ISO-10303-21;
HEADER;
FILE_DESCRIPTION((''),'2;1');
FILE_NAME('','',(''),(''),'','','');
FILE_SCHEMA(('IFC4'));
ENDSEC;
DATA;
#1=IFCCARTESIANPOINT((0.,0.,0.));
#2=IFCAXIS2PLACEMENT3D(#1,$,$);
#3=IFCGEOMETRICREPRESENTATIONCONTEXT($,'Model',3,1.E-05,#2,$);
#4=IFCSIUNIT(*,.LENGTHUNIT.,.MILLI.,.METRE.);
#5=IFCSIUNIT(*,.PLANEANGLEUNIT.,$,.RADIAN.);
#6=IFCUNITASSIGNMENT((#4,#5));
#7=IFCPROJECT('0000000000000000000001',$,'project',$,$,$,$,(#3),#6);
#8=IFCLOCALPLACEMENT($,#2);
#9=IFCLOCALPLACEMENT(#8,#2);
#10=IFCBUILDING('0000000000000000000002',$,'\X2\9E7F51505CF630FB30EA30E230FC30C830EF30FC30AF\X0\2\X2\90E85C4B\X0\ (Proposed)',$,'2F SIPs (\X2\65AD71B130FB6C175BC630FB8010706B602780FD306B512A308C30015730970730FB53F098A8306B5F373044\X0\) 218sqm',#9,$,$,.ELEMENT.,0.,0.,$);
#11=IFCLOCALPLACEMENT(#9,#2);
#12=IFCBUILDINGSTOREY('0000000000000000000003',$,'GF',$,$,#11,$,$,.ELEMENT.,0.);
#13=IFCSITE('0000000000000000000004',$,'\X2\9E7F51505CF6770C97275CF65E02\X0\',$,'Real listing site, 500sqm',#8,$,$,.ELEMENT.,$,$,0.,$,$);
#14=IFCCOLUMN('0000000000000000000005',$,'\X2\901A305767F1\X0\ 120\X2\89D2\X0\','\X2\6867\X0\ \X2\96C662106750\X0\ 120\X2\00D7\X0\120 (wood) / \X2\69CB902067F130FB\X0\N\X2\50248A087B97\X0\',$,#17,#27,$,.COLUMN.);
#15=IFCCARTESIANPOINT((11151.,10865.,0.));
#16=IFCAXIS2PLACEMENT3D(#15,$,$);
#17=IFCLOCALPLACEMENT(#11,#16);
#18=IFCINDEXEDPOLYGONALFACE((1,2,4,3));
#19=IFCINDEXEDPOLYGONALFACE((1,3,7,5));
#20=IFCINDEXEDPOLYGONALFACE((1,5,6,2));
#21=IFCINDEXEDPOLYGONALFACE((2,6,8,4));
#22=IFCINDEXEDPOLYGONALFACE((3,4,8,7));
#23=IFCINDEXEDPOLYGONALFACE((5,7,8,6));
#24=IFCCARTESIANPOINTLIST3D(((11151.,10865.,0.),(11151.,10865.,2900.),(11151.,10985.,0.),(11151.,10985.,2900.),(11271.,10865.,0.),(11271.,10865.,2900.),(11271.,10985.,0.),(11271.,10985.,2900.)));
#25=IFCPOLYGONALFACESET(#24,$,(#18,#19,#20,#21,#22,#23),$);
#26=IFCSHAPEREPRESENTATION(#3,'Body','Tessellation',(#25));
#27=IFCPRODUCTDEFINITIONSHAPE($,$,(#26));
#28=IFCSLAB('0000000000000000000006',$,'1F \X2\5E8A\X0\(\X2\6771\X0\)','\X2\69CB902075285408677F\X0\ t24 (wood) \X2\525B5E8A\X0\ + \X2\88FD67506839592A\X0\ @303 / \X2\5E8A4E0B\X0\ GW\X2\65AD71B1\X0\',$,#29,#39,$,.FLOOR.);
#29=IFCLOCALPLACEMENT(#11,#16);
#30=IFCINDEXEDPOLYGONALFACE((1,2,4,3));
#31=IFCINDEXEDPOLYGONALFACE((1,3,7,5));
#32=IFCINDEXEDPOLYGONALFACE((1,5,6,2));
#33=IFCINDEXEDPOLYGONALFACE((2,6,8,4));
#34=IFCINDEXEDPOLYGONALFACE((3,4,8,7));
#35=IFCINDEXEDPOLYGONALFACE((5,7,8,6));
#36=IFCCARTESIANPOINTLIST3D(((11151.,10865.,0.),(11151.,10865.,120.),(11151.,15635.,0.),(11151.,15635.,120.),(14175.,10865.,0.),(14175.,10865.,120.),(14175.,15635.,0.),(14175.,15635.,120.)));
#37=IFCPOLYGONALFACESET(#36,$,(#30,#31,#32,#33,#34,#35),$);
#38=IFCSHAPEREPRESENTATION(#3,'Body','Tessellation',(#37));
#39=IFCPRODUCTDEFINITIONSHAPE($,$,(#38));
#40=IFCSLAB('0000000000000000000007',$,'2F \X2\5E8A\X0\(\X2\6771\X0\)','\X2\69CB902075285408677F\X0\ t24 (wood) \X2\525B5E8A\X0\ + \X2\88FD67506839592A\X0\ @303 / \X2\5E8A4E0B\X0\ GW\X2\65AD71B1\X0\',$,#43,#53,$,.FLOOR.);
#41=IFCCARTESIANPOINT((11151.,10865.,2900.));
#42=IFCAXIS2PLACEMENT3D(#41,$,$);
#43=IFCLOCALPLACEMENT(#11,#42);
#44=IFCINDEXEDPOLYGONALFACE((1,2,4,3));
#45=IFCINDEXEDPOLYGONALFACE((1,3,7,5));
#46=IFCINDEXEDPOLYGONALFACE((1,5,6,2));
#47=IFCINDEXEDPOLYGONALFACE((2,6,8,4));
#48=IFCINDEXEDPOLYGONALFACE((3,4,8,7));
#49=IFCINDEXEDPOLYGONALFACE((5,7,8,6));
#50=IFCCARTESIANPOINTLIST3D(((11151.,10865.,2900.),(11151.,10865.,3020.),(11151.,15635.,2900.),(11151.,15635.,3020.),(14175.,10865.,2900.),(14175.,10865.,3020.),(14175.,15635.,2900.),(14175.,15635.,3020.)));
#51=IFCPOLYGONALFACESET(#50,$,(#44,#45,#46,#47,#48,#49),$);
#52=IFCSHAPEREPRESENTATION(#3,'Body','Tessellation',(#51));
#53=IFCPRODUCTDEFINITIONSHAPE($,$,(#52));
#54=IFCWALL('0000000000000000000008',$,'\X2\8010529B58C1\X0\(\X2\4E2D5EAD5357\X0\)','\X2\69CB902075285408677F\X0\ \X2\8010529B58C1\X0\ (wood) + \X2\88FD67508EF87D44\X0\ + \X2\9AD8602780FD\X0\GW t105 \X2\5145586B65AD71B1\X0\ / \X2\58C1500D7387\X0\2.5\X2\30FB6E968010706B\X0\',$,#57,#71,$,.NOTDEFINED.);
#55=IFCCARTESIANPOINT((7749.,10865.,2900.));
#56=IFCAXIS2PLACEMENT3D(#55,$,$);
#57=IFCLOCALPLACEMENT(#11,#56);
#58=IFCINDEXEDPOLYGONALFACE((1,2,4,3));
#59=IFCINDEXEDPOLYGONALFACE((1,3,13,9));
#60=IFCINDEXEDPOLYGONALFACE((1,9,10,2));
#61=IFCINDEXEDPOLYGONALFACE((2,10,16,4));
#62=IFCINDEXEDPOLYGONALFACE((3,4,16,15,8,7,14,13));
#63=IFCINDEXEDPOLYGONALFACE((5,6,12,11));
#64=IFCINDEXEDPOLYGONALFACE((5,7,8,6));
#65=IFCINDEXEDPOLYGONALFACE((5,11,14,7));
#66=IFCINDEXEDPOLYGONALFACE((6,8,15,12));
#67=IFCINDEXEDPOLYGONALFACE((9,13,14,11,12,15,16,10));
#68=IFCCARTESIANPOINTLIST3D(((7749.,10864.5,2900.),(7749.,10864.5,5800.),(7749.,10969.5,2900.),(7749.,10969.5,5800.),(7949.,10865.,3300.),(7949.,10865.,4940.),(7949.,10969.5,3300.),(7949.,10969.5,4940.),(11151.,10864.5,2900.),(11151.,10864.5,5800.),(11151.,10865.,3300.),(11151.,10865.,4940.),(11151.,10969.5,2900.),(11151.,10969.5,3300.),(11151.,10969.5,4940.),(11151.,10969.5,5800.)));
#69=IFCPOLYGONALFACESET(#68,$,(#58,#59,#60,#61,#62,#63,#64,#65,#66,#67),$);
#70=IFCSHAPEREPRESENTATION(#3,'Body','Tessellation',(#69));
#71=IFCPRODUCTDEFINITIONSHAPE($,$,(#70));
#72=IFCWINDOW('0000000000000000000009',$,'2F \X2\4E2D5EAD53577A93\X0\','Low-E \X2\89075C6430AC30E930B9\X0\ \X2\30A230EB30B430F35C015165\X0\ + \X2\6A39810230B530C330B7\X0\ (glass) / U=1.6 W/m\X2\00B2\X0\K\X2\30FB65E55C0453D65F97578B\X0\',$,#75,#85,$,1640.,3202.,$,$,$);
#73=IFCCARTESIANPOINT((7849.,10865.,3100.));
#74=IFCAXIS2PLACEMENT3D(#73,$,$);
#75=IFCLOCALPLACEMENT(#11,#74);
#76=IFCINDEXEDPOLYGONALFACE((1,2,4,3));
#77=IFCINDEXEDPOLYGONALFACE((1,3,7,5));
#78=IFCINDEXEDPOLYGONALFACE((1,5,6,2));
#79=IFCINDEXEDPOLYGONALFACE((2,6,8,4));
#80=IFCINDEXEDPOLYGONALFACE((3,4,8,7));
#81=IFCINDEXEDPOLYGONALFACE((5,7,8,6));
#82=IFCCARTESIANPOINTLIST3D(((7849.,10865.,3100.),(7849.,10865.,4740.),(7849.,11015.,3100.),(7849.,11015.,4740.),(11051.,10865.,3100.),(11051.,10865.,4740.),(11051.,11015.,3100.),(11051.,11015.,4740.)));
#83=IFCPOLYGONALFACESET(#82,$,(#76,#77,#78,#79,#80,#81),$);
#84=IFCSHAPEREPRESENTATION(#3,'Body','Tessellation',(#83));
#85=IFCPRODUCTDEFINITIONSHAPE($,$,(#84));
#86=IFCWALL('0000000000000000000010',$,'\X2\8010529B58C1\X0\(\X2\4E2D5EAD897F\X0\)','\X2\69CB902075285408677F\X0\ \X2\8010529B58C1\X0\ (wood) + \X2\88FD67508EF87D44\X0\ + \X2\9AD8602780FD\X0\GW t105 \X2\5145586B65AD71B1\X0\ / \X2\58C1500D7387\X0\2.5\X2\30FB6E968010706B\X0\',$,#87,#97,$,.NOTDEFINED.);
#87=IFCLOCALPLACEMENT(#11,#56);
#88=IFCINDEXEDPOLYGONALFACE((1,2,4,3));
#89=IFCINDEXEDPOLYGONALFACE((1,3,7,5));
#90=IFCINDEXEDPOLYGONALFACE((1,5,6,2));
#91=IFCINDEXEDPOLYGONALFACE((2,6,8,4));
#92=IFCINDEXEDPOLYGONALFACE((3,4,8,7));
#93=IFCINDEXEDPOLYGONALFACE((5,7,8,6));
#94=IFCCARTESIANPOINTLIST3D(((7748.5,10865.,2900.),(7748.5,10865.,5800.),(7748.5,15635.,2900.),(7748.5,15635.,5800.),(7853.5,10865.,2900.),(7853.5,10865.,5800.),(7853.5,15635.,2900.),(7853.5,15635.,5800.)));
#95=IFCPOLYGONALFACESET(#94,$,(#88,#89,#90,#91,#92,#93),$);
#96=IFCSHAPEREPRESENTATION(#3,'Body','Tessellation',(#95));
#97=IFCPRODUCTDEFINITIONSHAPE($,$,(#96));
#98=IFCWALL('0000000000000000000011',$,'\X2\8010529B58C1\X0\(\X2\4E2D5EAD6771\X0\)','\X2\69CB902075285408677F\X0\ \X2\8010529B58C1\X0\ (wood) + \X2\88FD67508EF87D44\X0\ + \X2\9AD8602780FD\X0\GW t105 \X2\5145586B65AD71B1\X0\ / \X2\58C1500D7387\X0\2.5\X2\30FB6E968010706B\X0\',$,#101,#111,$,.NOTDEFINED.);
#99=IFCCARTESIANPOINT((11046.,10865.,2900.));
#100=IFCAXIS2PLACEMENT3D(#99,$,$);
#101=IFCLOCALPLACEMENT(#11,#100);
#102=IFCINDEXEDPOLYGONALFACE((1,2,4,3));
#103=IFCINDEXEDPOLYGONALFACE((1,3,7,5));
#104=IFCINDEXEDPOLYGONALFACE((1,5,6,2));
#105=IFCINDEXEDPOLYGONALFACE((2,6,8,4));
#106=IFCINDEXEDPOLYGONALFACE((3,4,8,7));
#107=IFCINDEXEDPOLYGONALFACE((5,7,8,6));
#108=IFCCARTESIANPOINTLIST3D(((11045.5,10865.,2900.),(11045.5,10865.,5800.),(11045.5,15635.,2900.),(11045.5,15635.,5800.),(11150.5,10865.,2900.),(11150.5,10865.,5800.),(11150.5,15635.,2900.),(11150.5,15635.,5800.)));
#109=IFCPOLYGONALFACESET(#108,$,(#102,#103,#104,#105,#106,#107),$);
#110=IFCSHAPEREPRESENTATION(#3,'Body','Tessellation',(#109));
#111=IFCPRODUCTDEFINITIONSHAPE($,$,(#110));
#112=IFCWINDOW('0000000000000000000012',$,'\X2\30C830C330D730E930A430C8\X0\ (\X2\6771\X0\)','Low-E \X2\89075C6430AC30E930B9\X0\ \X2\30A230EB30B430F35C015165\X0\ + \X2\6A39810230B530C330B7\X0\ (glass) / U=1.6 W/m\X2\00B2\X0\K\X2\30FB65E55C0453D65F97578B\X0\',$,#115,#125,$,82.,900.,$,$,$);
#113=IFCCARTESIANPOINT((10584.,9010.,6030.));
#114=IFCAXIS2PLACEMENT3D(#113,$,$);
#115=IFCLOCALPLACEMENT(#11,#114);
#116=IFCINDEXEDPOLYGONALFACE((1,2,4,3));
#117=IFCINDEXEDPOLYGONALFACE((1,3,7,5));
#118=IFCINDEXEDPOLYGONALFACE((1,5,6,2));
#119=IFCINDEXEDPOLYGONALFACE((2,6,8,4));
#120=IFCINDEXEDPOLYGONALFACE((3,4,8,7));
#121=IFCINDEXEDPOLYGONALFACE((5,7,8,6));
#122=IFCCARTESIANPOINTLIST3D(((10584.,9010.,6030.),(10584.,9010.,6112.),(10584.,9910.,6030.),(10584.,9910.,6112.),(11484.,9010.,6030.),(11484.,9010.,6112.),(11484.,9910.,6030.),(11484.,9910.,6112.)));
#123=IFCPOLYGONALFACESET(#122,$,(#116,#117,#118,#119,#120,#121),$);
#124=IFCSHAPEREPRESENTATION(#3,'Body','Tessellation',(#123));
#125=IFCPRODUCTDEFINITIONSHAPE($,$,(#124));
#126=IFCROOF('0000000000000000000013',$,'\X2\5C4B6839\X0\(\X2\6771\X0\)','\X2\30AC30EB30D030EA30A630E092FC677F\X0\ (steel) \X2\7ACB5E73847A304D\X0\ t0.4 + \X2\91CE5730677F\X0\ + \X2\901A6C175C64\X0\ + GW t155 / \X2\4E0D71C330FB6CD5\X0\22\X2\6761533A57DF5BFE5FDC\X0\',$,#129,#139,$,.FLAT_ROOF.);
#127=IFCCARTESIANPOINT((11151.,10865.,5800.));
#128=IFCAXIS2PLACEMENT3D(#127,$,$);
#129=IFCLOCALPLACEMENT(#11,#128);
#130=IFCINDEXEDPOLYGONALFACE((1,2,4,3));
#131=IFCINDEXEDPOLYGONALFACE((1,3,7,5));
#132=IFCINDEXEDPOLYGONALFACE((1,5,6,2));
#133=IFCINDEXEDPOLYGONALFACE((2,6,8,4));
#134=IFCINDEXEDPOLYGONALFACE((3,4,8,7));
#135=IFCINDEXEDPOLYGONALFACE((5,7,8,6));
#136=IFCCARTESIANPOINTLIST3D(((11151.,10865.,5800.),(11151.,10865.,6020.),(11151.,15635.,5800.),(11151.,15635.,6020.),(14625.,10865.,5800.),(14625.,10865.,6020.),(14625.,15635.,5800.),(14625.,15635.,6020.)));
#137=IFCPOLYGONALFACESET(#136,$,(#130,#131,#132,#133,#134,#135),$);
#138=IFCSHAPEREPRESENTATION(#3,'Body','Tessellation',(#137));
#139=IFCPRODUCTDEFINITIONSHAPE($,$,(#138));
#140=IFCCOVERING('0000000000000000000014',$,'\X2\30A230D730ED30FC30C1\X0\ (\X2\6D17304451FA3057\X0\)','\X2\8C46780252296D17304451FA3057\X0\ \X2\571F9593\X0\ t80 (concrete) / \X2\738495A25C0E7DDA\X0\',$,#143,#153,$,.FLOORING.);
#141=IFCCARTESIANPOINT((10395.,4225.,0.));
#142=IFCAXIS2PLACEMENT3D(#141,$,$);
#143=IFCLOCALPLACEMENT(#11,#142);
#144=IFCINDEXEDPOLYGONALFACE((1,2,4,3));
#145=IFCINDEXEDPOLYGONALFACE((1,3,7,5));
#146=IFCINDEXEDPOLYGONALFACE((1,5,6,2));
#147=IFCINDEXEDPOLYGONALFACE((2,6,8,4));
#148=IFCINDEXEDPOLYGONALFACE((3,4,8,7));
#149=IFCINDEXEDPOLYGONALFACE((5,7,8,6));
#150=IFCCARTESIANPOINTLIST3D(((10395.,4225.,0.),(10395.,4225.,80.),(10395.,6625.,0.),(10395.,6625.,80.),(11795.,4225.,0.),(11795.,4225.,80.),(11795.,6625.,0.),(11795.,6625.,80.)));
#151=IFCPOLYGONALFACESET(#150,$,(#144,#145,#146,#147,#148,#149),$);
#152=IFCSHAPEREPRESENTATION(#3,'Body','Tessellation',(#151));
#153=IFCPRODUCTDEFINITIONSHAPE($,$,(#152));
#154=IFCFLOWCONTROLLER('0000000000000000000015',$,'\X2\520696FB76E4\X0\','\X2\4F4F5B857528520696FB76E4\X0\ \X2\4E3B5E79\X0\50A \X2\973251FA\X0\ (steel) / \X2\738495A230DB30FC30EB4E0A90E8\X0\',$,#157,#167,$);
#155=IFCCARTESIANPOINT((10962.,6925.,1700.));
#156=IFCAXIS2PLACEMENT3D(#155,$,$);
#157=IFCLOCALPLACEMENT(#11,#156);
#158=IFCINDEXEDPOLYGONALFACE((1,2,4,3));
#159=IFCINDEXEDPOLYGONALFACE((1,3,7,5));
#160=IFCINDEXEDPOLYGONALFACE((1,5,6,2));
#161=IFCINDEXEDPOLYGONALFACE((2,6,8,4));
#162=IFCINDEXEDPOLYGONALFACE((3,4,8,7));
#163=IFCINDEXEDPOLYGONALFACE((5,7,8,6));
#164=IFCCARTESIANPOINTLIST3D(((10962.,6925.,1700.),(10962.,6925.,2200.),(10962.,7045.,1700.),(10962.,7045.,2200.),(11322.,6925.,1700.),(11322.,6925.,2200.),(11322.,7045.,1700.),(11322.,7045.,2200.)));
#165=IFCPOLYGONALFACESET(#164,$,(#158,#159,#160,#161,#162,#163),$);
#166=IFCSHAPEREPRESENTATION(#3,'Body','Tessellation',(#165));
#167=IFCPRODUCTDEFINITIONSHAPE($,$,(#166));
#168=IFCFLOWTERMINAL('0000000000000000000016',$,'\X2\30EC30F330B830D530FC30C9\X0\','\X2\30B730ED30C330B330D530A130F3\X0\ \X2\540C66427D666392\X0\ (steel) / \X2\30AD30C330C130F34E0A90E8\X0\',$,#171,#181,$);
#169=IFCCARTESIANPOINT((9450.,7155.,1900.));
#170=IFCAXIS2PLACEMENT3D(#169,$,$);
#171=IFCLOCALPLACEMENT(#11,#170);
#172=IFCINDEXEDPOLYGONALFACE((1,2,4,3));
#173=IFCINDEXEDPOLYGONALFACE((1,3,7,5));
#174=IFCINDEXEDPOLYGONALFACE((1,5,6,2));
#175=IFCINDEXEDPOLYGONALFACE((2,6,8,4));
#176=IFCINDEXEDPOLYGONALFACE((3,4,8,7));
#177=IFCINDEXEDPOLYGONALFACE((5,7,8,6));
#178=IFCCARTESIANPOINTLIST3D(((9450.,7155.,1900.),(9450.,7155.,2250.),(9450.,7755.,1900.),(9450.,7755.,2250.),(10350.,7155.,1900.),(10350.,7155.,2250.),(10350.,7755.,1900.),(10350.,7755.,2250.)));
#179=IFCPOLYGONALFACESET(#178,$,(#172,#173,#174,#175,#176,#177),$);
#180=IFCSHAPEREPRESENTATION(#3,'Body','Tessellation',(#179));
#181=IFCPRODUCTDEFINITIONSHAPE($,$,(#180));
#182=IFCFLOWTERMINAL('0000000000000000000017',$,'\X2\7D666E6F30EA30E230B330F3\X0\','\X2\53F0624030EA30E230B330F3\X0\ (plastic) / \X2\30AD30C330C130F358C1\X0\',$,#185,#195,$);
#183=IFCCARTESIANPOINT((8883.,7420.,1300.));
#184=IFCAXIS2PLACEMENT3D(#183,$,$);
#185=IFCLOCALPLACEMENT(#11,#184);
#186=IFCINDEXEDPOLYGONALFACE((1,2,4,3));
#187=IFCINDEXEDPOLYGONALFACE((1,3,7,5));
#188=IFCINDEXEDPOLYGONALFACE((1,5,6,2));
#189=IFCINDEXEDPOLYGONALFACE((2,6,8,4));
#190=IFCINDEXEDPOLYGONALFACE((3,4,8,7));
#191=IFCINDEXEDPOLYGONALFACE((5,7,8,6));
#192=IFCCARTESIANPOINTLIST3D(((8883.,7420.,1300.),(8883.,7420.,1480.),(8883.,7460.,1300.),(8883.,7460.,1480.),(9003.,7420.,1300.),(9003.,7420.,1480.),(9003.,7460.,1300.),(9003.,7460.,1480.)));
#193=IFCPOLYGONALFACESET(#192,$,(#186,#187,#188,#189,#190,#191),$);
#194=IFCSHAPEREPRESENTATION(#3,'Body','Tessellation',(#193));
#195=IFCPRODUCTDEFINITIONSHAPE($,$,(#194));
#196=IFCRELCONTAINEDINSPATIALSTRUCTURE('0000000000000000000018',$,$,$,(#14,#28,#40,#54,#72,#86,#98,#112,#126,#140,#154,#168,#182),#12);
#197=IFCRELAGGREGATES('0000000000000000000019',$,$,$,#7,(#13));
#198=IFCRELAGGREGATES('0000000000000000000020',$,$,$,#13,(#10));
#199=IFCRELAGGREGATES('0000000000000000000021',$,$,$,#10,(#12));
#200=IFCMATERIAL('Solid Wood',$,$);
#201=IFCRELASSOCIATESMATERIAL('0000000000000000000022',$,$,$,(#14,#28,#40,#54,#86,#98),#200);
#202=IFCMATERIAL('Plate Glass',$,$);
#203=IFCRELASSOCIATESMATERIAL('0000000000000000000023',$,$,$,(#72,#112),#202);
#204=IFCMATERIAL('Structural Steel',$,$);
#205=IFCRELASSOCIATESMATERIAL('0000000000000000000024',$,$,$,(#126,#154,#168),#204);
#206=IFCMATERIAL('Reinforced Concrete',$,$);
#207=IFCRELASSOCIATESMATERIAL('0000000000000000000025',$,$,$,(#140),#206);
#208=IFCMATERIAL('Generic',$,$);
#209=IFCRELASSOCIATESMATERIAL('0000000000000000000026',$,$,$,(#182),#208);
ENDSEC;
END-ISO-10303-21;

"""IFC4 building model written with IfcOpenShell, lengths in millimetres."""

from ifc_helpers import new_model, si_unit, frame, frame_2d, origin, place, context, project, spatial, rectangle, extrude, material, element, fill, save


model = new_model("IFC4")

# Units and contexts
model_context = context("Model", 3, precision=1e-05, world=origin())
ifc_project = project(units=[si_unit("LENGTHUNIT", "METRE", prefix="MILLI"), si_unit("PLANEANGLEUNIT", "RADIAN")], contexts=[model_context])

# Site, building, storey
site_placement = place(None, origin())
site = spatial("IfcSite", under=ifc_project, at=site_placement, Name="鹿児島県霧島市", ObjectType="Real listing site, 500sqm", CompositionType="ELEMENT", RefElevation=0.0)
building_placement = place(site_placement, origin())
building = spatial("IfcBuilding", under=site, at=building_placement, Name="鹿児島・リモートワーク2部屋 (Proposed)", ObjectType="2F SIPs (断熱・気密・耐火性能に優れ、地震・台風に強い) 218sqm", CompositionType="ELEMENT", ElevationOfRefHeight=0.0, ElevationOfTerrain=0.0)
storey_placement = place(building_placement, origin())
storey = spatial("IfcBuildingStorey", under=building, at=storey_placement, Name="GF", CompositionType="ELEMENT", Elevation=0.0)

# Column
ifc_material_1 = material(Name="Solid Wood")
column_1_placement = place(storey_placement, frame((11151.0, 10865.0, 0.0)))
element("IfcColumn", 1, at=column_1_placement, inside=storey, material=ifc_material_1, Name="通し柱 120角", Description="桧 集成材 120×120 (wood) / 構造柱・N値計算", PredefinedType="COLUMN", context=model_context, shape_type="SweptSolid", body=[
    extrude(rectangle(XDim=120.0, YDim=120.0, at=frame_2d((60.0, 60.0))), frame((11151.0, 10865.0, 0.0)), (0.0, 0.0, 1.0), 2900.0),
])

# Slabs
slab_1_placement = place(storey_placement, frame((11151.0, 10865.0, 0.0)))
element("IfcSlab", 2, at=slab_1_placement, inside=storey, material=ifc_material_1, Name="1F 床(東)", Description="構造用合板 t24 (wood) 剛床 + 製材根太 @303 / 床下 GW断熱", PredefinedType="FLOOR", context=model_context, shape_type="SweptSolid", body=[
    extrude(rectangle(XDim=3024.0, YDim=4770.0, at=frame_2d((1512.0, 2385.0))), frame((11151.0, 10865.0, 0.0)), (0.0, 0.0, 1.0), 120.0),
])
slab_2_placement = place(storey_placement, frame((11151.0, 10865.0, 2900.0)))
element("IfcSlab", 3, at=slab_2_placement, inside=storey, material=ifc_material_1, Name="2F 床(東)", Description="構造用合板 t24 (wood) 剛床 + 製材根太 @303 / 床下 GW断熱", PredefinedType="FLOOR", context=model_context, shape_type="SweptSolid", body=[
    extrude(rectangle(XDim=3024.0, YDim=4770.0, at=frame_2d((1512.0, 2385.0))), frame((11151.0, 10865.0, 2900.0)), (0.0, 0.0, 1.0), 120.0),
])

# Wall, opening, window
wall_1_placement = place(storey_placement, frame((7749.0, 10865.0, 2900.0)))
wall_1 = element("IfcWall", 4, at=wall_1_placement, inside=storey, material=ifc_material_1, Name="耐力壁(中庭南)", Description="構造用合板 耐力壁 (wood) + 製材軸組 + 高性能GW t105 充填断熱 / 壁倍率2.5・準耐火", PredefinedType="NOTDEFINED", context=model_context, shape_type="SweptSolid", body=[
    extrude(rectangle(XDim=3402.0, YDim=105.0, at=frame_2d((1701.0, 52.0))), frame((7749.0, 10865.0, 2900.0)), (0.0, 0.0, 1.0), 2900.0),
])
opening_placement = place(storey_placement, frame((7849.0, 10865.0, 3100.0)))
opening = element("IfcOpeningElement", 5, at=opening_placement, cuts=wall_1, PredefinedType="NOTDEFINED", context=model_context, shape_type="SweptSolid", body=[
    extrude(rectangle(XDim=3202.0, YDim=150.0, at=frame_2d((1601.0, 75.0))), frame((7849.0, 10865.0, 3100.0)), (0.0, 0.0, 1.0), 1640.0),
])
ifc_material_2 = material(Name="Plate Glass")
window_1_placement = place(storey_placement, frame((7849.0, 10865.0, 3100.0)))
window_1 = element("IfcWindow", 6, at=window_1_placement, inside=storey, material=ifc_material_2, Name="2F 中庭南窓", Description="Low-E 複層ガラス アルゴン封入 + 樹脂サッシ (glass) / U=1.6 W/m²K・日射取得型", OverallHeight=1640.0, OverallWidth=3202.0, context=model_context, shape_type="SweptSolid", body=[
    extrude(rectangle(XDim=3202.0, YDim=150.0, at=frame_2d((1601.0, 75.0))), frame((7849.0, 10865.0, 3100.0)), (0.0, 0.0, 1.0), 1640.0),
])
fill(opening, window_1)

# Walls
wall_2_placement = place(storey_placement, frame((7749.0, 10865.0, 2900.0)))
element("IfcWall", 7, at=wall_2_placement, inside=storey, material=ifc_material_1, Name="耐力壁(中庭西)", Description="構造用合板 耐力壁 (wood) + 製材軸組 + 高性能GW t105 充填断熱 / 壁倍率2.5・準耐火", PredefinedType="NOTDEFINED", context=model_context, shape_type="SweptSolid", body=[
    extrude(rectangle(XDim=105.0, YDim=4770.0, at=frame_2d((52.0, 2385.0))), frame((7749.0, 10865.0, 2900.0)), (0.0, 0.0, 1.0), 2900.0),
])
wall_3_placement = place(storey_placement, frame((11046.0, 10865.0, 2900.0)))
element("IfcWall", 8, at=wall_3_placement, inside=storey, material=ifc_material_1, Name="耐力壁(中庭東)", Description="構造用合板 耐力壁 (wood) + 製材軸組 + 高性能GW t105 充填断熱 / 壁倍率2.5・準耐火", PredefinedType="NOTDEFINED", context=model_context, shape_type="SweptSolid", body=[
    extrude(rectangle(XDim=105.0, YDim=4770.0, at=frame_2d((52.0, 2385.0))), frame((11046.0, 10865.0, 2900.0)), (0.0, 0.0, 1.0), 2900.0),
])

# Window
window_2_placement = place(storey_placement, frame((10584.0, 9010.0, 6030.0)))
element("IfcWindow", 9, at=window_2_placement, inside=storey, material=ifc_material_2, Name="トップライト (東)", Description="Low-E 複層ガラス アルゴン封入 + 樹脂サッシ (glass) / U=1.6 W/m²K・日射取得型", OverallHeight=82.0, OverallWidth=900.0, context=model_context, shape_type="SweptSolid", body=[
    extrude(rectangle(XDim=900.0, YDim=900.0, at=frame_2d((450.0, 450.0))), frame((10584.0, 9010.0, 6030.0)), (0.0, 0.0, 1.0), 82.0),
])

# Roof
ifc_material_3 = material(Name="Structural Steel")
for number, where, name in (
    (10, (11151.0, 10865.0, 5800.0), "屋根(東)"),
):
    element("IfcRoof", number, at=place(storey_placement, frame(where)), inside=storey, material=ifc_material_3, Name=name, Description="ガルバリウム鋼板 (steel) 立平葺き t0.4 + 野地板 + 通気層 + GW t155 / 不燃・法22条区域対応", PredefinedType="FLAT_ROOF", context=model_context, shape_type="SweptSolid", body=[
        extrude(rectangle(XDim=3474.0, YDim=4770.0, at=frame_2d((1737.0, 2385.0))), frame((11151.0, 10865.0, 5800.0)), (0.0, 0.0, 1.0), 220.0),
    ])

# Covering
ifc_material_4 = material(Name="Reinforced Concrete")
covering_placement = place(storey_placement, frame((10395.0, 4225.0, 0.0)))
element("IfcCovering", 11, at=covering_placement, inside=storey, material=ifc_material_4, Name="アプローチ (洗い出し)", Description="豆砂利洗い出し 土間 t80 (concrete) / 玄関導線", PredefinedType="FLOORING", context=model_context, shape_type="SweptSolid", body=[
    extrude(rectangle(XDim=1400.0, YDim=2400.0, at=frame_2d((700.0, 1200.0))), frame((10395.0, 4225.0, 0.0)), (0.0, 0.0, 1.0), 80.0),
])

# Flow controller
flow_controller_placement = place(storey_placement, frame((10962.0, 6925.0, 1700.0)))
element("IfcFlowController", 12, at=flow_controller_placement, inside=storey, material=ifc_material_3, Name="分電盤", Description="住宅用分電盤 主幹50A 露出 (steel) / 玄関ホール上部", context=model_context, shape_type="SweptSolid", body=[
    extrude(rectangle(XDim=360.0, YDim=120.0, at=frame_2d((180.0, 60.0))), frame((10962.0, 6925.0, 1700.0)), (0.0, 0.0, 1.0), 500.0),
])

# Flow terminals
flow_terminal_1_placement = place(storey_placement, frame((9450.0, 7155.0, 1900.0)))
element("IfcFlowTerminal", 13, at=flow_terminal_1_placement, inside=storey, material=ifc_material_3, Name="レンジフード", Description="シロッコファン 同時給排 (steel) / キッチン上部", context=model_context, shape_type="SweptSolid", body=[
    extrude(rectangle(XDim=900.0, YDim=600.0, at=frame_2d((450.0, 300.0))), frame((9450.0, 7155.0, 1900.0)), (0.0, 0.0, 1.0), 350.0),
])
ifc_material_5 = material(Name="Generic")
flow_terminal_2_placement = place(storey_placement, frame((8883.0, 7420.0, 1300.0)))
element("IfcFlowTerminal", 14, at=flow_terminal_2_placement, inside=storey, material=ifc_material_5, Name="給湯リモコン", Description="台所リモコン (plastic) / キッチン壁", context=model_context, shape_type="SweptSolid", body=[
    extrude(rectangle(XDim=120.0, YDim=40.0, at=frame_2d((60.0, 20.0))), frame((8883.0, 7420.0, 1300.0)), (0.0, 0.0, 1.0), 180.0),
])

save(model, "model.ifc")
